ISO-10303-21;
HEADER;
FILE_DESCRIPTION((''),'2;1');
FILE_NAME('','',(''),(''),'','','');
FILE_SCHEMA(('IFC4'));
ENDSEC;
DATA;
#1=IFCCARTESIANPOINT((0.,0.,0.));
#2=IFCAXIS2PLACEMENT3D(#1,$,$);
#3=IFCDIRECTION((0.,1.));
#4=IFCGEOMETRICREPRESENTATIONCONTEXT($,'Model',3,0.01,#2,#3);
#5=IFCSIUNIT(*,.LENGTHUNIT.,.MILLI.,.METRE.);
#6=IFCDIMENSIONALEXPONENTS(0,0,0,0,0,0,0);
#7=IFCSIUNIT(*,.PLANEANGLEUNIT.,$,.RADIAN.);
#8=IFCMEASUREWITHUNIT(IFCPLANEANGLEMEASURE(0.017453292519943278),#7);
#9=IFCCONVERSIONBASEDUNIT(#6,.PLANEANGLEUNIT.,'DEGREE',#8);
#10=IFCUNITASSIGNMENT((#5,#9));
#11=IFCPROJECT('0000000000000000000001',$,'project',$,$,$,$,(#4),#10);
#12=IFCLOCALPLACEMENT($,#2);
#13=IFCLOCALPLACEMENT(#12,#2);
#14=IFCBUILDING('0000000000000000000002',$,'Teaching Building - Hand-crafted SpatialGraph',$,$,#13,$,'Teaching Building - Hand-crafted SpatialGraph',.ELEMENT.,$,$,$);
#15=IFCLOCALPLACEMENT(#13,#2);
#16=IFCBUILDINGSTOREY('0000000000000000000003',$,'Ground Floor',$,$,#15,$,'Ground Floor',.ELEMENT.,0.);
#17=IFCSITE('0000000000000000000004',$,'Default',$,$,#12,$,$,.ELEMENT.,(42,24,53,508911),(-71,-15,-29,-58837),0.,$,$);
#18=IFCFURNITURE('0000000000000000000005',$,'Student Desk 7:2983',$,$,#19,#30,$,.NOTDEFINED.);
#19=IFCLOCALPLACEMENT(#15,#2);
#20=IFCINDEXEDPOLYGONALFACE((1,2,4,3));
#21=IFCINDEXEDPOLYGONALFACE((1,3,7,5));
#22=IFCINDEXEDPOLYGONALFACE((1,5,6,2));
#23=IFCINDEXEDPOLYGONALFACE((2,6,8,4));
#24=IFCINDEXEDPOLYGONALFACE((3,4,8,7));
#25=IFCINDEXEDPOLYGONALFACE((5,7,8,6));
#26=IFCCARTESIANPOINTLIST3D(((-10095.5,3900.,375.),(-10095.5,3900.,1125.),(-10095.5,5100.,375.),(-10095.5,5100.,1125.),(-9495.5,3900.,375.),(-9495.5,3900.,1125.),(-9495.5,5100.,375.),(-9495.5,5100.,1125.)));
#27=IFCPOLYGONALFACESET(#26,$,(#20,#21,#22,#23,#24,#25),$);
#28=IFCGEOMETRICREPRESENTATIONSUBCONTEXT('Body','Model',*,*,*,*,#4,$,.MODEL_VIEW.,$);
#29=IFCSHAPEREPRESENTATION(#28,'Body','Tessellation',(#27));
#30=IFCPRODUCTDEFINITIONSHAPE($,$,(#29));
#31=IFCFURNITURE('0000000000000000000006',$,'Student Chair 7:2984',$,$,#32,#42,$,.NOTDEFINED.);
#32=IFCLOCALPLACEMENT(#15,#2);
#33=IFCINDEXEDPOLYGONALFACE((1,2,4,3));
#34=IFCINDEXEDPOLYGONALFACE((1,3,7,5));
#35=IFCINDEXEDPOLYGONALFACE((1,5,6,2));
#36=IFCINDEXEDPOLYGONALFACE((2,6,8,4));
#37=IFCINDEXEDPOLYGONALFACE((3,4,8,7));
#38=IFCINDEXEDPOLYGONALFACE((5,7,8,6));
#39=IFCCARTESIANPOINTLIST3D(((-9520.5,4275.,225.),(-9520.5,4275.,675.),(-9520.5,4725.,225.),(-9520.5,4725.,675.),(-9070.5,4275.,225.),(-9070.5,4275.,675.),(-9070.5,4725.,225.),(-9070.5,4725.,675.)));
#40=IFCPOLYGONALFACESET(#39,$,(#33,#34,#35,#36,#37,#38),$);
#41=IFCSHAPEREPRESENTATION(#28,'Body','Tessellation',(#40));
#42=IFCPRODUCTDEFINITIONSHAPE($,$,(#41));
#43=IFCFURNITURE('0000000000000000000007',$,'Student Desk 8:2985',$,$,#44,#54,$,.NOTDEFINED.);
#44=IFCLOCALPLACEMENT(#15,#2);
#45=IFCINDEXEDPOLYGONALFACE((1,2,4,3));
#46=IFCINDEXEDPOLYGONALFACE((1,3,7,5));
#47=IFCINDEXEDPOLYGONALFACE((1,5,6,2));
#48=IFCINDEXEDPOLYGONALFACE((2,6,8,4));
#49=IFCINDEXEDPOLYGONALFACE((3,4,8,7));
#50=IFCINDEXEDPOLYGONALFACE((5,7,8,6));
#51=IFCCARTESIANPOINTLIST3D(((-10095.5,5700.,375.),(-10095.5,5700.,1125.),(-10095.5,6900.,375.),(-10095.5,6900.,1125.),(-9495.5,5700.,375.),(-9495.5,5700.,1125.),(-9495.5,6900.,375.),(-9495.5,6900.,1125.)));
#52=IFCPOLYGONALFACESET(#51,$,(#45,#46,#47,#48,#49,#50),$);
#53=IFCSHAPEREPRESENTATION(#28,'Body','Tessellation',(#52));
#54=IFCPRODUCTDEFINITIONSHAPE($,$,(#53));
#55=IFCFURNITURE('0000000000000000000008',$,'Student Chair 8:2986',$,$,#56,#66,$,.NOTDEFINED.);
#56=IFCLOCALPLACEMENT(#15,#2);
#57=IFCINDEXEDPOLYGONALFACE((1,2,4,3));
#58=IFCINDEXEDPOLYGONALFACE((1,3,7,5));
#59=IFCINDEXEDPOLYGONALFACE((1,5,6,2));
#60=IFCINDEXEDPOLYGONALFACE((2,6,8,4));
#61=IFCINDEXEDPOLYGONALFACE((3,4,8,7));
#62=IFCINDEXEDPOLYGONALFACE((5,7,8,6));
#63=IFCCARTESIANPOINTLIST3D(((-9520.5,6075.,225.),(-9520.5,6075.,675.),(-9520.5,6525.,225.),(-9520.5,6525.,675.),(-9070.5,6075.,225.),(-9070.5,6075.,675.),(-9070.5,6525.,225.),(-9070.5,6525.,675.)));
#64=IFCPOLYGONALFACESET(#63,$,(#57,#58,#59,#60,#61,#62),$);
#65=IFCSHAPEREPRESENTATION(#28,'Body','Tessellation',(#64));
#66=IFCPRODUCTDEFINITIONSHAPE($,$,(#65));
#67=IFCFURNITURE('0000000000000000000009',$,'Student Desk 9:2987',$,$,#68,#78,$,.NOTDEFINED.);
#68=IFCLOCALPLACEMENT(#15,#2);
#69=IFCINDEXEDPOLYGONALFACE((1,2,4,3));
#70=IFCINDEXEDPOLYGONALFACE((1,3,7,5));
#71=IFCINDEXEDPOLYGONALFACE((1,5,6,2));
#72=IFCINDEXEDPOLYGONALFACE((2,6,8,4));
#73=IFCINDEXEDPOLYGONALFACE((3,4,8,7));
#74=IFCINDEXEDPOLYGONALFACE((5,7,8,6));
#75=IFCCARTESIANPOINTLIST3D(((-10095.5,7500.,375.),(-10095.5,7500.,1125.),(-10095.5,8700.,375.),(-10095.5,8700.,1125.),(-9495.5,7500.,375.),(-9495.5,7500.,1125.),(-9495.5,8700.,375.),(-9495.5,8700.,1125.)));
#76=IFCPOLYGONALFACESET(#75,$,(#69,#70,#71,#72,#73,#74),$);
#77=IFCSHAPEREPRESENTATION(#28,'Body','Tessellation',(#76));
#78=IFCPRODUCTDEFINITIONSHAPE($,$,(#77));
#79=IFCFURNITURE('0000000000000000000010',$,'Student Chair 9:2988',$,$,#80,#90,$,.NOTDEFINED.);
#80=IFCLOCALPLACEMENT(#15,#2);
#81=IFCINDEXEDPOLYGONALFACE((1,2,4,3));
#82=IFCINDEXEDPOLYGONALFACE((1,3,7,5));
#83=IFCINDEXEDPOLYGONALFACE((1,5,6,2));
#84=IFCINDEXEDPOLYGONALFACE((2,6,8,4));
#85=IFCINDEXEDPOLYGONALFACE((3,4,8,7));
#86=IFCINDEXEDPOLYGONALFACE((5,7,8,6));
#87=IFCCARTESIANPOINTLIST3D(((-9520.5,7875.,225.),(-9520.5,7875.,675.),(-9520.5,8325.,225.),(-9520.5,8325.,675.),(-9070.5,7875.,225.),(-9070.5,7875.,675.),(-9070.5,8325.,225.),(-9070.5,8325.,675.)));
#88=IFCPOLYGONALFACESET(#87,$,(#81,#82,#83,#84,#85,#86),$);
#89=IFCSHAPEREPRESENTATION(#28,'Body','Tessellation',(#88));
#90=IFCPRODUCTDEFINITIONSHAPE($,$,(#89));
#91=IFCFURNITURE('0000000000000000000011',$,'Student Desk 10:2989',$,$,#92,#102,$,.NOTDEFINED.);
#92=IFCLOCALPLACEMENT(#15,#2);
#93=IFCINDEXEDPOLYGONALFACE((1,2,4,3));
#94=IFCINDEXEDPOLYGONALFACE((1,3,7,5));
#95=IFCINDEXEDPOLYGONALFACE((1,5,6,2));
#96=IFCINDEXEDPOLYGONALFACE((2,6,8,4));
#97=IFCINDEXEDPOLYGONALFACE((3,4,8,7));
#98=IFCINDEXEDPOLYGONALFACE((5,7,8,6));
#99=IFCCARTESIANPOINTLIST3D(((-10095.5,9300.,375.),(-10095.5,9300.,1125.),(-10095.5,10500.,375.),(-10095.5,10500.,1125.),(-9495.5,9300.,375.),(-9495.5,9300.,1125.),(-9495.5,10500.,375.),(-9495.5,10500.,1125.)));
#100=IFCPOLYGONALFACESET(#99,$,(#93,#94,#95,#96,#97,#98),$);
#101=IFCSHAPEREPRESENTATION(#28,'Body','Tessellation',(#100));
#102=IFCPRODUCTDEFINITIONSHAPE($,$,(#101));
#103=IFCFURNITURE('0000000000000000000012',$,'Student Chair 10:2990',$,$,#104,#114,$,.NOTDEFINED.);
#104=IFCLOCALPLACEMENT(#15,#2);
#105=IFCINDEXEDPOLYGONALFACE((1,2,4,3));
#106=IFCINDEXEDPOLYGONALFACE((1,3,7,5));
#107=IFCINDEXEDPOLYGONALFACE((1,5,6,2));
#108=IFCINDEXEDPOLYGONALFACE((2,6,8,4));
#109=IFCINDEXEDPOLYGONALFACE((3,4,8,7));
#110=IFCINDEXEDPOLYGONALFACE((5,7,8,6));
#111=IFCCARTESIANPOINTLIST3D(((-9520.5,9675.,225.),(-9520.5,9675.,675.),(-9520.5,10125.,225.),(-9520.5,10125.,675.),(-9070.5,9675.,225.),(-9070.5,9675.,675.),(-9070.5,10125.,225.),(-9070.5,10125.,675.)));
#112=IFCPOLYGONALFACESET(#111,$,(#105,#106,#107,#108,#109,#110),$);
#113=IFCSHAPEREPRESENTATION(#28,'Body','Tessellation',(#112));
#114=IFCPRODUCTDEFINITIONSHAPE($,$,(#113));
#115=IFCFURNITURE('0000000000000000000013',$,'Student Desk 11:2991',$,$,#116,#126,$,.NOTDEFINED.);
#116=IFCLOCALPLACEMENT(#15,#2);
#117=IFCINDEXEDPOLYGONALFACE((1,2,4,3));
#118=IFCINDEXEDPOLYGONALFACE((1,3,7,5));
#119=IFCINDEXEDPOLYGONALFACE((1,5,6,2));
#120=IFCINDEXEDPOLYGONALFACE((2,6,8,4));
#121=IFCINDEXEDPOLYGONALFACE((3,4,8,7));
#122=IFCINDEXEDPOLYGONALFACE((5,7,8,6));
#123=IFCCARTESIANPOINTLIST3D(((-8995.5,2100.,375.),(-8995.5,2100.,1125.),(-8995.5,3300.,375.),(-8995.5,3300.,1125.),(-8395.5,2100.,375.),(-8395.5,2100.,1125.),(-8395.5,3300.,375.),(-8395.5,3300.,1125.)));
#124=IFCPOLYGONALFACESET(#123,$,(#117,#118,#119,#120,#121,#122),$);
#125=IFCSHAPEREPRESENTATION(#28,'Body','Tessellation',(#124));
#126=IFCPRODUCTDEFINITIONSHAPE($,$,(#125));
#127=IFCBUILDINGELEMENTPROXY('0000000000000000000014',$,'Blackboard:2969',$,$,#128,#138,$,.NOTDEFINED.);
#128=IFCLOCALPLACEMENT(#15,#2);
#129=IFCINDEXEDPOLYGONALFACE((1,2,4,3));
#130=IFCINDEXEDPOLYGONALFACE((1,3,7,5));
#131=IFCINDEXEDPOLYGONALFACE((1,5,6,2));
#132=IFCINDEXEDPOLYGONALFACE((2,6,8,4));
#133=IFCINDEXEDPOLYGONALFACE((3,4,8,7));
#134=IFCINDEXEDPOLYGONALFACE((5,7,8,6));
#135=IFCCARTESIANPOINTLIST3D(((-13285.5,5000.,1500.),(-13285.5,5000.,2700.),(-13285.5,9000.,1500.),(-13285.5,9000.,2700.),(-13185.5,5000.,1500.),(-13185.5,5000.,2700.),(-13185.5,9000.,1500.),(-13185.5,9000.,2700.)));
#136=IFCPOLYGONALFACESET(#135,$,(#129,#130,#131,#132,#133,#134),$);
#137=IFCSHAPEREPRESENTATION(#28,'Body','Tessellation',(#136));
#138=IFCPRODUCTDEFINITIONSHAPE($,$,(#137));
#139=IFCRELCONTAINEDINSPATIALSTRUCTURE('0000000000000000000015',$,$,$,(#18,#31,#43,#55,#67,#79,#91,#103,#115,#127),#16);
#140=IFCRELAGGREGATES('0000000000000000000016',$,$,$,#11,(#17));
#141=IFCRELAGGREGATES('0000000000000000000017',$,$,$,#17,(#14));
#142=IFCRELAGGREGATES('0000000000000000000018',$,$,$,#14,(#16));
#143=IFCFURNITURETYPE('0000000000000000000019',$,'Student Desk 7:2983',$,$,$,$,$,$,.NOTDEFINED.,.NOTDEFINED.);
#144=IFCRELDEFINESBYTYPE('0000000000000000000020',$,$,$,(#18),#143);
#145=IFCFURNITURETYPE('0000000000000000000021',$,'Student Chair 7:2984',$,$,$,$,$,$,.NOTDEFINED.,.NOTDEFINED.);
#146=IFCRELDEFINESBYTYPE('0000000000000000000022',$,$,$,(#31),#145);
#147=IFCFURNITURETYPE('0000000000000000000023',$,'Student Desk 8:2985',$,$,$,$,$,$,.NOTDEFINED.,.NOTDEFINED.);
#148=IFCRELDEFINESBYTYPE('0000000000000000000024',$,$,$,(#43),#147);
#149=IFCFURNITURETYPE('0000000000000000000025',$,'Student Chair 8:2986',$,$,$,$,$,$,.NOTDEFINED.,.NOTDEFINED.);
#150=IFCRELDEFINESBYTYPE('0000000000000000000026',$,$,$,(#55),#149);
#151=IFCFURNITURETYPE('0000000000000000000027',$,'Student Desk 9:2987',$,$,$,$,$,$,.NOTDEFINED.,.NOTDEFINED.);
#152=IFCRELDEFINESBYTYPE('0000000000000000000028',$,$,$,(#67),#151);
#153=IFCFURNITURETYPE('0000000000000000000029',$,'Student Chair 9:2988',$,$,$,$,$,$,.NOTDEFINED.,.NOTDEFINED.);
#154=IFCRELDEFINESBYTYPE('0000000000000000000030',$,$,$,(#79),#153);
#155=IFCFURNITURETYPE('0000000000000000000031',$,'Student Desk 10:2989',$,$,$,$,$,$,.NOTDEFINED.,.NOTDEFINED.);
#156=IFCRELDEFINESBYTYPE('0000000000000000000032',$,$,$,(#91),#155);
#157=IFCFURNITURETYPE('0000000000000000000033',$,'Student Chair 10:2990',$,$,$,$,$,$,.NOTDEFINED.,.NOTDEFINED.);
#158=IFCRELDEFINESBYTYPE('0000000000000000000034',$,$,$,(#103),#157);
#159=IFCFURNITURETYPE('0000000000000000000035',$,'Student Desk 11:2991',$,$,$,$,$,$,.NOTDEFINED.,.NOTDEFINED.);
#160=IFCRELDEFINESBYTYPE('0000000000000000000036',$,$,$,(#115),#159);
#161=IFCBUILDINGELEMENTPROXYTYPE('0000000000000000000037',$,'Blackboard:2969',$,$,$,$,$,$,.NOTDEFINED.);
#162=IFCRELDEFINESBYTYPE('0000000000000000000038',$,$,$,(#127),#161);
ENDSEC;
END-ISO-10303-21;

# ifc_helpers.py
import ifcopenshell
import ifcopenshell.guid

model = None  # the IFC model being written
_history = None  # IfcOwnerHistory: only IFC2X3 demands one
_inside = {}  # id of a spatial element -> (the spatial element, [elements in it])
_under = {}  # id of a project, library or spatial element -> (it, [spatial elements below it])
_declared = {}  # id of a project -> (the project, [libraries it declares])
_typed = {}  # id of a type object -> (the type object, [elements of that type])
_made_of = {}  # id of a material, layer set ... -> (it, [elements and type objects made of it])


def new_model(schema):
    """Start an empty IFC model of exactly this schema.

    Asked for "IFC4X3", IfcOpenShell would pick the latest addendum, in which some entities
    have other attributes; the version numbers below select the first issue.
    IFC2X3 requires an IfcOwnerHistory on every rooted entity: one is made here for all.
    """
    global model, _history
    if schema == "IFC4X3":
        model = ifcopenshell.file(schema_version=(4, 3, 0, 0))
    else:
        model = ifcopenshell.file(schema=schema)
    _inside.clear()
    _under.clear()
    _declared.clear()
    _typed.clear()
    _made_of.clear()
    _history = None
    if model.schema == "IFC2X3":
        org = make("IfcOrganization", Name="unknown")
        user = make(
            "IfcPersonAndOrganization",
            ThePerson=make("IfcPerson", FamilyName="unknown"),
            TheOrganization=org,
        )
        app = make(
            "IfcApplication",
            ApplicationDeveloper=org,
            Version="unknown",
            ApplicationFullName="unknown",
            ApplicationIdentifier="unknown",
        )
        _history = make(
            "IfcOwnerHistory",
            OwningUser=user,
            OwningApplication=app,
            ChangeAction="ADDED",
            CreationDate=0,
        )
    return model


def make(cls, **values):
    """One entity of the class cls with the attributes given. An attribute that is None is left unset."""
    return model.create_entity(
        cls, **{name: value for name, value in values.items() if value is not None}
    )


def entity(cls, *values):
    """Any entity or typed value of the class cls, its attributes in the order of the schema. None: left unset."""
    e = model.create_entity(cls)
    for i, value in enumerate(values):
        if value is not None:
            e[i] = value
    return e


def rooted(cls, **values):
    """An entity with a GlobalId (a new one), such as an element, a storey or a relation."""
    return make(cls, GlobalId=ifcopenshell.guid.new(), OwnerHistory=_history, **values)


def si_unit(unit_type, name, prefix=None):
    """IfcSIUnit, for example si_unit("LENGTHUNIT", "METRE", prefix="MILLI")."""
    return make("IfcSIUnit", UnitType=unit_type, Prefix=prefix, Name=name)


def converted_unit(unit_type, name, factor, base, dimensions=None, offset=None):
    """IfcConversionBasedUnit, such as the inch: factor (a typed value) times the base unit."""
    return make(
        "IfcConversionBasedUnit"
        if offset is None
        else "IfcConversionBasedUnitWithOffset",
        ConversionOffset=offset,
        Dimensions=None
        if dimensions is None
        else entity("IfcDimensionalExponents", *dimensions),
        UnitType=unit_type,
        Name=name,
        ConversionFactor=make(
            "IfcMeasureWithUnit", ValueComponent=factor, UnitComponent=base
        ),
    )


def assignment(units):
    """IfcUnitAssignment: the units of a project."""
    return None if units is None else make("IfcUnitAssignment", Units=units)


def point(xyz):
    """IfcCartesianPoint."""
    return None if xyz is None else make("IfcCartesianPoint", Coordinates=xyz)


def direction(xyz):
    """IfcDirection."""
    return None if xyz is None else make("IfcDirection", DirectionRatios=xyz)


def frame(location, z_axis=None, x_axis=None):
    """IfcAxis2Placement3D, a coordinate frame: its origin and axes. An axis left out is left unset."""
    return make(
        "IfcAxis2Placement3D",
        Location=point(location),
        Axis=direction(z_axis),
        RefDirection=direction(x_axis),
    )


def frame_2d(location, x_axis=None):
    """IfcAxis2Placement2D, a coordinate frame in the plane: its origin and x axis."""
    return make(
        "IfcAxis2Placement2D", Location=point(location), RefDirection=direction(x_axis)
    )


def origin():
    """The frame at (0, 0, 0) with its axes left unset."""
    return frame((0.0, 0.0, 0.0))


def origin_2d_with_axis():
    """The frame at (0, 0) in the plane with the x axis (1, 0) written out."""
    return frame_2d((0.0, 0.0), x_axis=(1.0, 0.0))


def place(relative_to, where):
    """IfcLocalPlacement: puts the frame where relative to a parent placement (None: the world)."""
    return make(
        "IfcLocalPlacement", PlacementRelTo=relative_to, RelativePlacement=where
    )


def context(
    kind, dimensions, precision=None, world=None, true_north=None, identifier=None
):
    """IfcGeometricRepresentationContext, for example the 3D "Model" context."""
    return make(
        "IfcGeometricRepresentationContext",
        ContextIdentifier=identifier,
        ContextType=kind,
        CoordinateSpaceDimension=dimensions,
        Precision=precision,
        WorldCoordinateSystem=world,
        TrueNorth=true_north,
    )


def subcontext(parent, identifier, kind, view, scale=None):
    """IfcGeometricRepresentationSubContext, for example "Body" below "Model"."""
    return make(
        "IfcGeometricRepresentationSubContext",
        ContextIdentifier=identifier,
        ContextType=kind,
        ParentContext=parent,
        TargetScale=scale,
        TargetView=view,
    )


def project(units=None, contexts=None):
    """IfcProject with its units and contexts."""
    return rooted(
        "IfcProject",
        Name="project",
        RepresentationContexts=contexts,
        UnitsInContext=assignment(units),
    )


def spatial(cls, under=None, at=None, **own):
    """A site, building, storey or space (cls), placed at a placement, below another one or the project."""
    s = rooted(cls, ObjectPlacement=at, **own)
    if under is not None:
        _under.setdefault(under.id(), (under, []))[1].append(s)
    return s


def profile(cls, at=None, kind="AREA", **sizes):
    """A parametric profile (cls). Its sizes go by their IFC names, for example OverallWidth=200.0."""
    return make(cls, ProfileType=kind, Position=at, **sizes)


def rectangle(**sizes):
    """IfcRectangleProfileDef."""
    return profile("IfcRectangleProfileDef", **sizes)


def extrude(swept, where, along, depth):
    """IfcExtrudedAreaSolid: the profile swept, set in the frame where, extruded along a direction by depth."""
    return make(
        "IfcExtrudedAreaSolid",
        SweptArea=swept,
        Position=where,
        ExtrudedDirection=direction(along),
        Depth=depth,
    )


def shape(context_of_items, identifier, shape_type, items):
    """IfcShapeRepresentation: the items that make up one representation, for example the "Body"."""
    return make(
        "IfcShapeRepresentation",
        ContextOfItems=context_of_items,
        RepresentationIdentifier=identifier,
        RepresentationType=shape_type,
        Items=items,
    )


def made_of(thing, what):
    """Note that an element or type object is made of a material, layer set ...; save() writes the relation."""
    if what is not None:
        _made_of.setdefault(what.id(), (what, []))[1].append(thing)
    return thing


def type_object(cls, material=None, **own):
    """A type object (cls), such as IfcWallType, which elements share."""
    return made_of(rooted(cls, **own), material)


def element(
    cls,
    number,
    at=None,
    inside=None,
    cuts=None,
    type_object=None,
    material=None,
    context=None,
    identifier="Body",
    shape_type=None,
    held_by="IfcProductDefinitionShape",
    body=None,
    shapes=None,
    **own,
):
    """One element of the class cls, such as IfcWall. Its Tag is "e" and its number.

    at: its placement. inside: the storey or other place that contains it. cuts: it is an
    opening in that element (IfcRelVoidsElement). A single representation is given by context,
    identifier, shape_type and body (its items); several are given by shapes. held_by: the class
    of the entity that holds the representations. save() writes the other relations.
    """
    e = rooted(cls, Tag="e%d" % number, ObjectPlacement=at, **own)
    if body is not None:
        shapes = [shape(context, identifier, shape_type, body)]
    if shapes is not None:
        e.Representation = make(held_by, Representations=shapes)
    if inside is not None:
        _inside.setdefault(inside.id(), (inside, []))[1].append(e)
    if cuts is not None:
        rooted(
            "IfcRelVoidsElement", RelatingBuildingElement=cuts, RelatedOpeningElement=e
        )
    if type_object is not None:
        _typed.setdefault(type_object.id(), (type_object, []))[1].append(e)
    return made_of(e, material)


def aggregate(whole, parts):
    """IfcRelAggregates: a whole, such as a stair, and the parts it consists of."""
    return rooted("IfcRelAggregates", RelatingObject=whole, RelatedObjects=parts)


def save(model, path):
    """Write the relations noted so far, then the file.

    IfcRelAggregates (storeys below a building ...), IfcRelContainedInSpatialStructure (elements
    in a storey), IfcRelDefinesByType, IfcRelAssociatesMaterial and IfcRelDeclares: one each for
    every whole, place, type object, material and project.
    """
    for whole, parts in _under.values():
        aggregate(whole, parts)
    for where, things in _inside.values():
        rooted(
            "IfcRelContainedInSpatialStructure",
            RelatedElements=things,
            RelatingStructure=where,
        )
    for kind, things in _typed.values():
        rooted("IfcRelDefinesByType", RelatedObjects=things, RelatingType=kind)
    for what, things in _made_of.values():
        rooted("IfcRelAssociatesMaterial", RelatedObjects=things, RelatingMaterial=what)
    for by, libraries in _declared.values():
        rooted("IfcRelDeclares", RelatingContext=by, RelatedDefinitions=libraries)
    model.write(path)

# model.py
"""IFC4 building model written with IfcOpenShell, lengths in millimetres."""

from ifc_helpers import new_model, entity, si_unit, converted_unit, direction, frame, frame_2d, origin, origin_2d_with_axis, place, context, subcontext, project, spatial, rectangle, extrude, type_object, element, save


model = new_model("IFC4")

# Units and contexts
model_context = context("Model", 3, precision=0.01, world=origin(), true_north=direction((0.0, 1.0)))
body_context = subcontext(model_context, "Body", "Model", "MODEL_VIEW")
ifc_project = project(units=[si_unit("LENGTHUNIT", "METRE", prefix="MILLI"), converted_unit("PLANEANGLEUNIT", "DEGREE", entity("IfcPlaneAngleMeasure", 0.017453292519943278), si_unit("PLANEANGLEUNIT", "RADIAN"), dimensions=[0, 0, 0, 0, 0, 0, 0])], contexts=[model_context])

# Site, building, storey
site_placement = place(None, origin())
site = spatial("IfcSite", under=ifc_project, at=site_placement, Name="Default", CompositionType="ELEMENT", RefLatitude=(42, 24, 53, 508911), RefLongitude=(-71, -15, -29, -58837), RefElevation=0.0)
building_placement = place(site_placement, origin())
building = spatial("IfcBuilding", under=site, at=building_placement, Name="Teaching Building - Hand-crafted SpatialGraph", LongName="Teaching Building - Hand-crafted SpatialGraph", CompositionType="ELEMENT")
storey_placement = place(building_placement, origin())
storey = spatial("IfcBuildingStorey", under=building, at=storey_placement, Name="Ground Floor", LongName="Ground Floor", CompositionType="ELEMENT", Elevation=0.0)

# Furniture
furniture_type_1 = type_object("IfcFurnitureType", Name="Student Desk 7:2983", PredefinedType="NOTDEFINED")
furniture_1_placement = place(storey_placement, origin())
element("IfcFurniture", 1, at=furniture_1_placement, inside=storey, type_object=furniture_type_1, Name="Student Desk 7:2983", PredefinedType="NOTDEFINED", context=body_context, shape_type="SweptSolid", body=[
    extrude(rectangle(XDim=1200.0, YDim=600.0, at=frame_2d((0.0, 0.0), x_axis=(1.0, 0.0))), frame((-9795.5, 4500.0, 375.0), z_axis=(0.0, 0.0, 1.0), x_axis=(0.0, 1.0, 0.0)), (0.0, 0.0, 1.0), 750.0),
])
furniture_type_2 = type_object("IfcFurnitureType", Name="Student Chair 7:2984", PredefinedType="NOTDEFINED")
furniture_2_placement = place(storey_placement, origin())
element("IfcFurniture", 2, at=furniture_2_placement, inside=storey, type_object=furniture_type_2, Name="Student Chair 7:2984", PredefinedType="NOTDEFINED", context=body_context, shape_type="SweptSolid", body=[
    extrude(rectangle(XDim=450.0, YDim=450.0, at=origin_2d_with_axis()), frame((-9295.5, 4500.0, 225.0)), (0.0, 0.0, 1.0), 450.0),
])
furniture_type_3 = type_object("IfcFurnitureType", Name="Student Desk 8:2985", PredefinedType="NOTDEFINED")
furniture_3_placement = place(storey_placement, origin())
element("IfcFurniture", 3, at=furniture_3_placement, inside=storey, type_object=furniture_type_3, Name="Student Desk 8:2985", PredefinedType="NOTDEFINED", context=body_context, shape_type="SweptSolid", body=[
    extrude(rectangle(XDim=1200.0, YDim=600.0, at=frame_2d((0.0, 0.0), x_axis=(1.0, 0.0))), frame((-9795.5, 6300.0, 375.0), z_axis=(0.0, 0.0, 1.0), x_axis=(0.0, 1.0, 0.0)), (0.0, 0.0, 1.0), 750.0),
])
furniture_type_4 = type_object("IfcFurnitureType", Name="Student Chair 8:2986", PredefinedType="NOTDEFINED")
furniture_4_placement = place(storey_placement, origin())
element("IfcFurniture", 4, at=furniture_4_placement, inside=storey, type_object=furniture_type_4, Name="Student Chair 8:2986", PredefinedType="NOTDEFINED", context=body_context, shape_type="SweptSolid", body=[
    extrude(rectangle(XDim=450.0, YDim=450.0, at=origin_2d_with_axis()), frame((-9295.5, 6300.0, 225.0)), (0.0, 0.0, 1.0), 450.0),
])
furniture_type_5 = type_object("IfcFurnitureType", Name="Student Desk 9:2987", PredefinedType="NOTDEFINED")
furniture_5_placement = place(storey_placement, origin())
element("IfcFurniture", 5, at=furniture_5_placement, inside=storey, type_object=furniture_type_5, Name="Student Desk 9:2987", PredefinedType="NOTDEFINED", context=body_context, shape_type="SweptSolid", body=[
    extrude(rectangle(XDim=1200.0, YDim=600.0, at=frame_2d((0.0, 0.0), x_axis=(1.0, 0.0))), frame((-9795.5, 8100.0, 375.0), z_axis=(0.0, 0.0, 1.0), x_axis=(0.0, 1.0, 0.0)), (0.0, 0.0, 1.0), 750.0),
])
furniture_type_6 = type_object("IfcFurnitureType", Name="Student Chair 9:2988", PredefinedType="NOTDEFINED")
furniture_6_placement = place(storey_placement, origin())
element("IfcFurniture", 6, at=furniture_6_placement, inside=storey, type_object=furniture_type_6, Name="Student Chair 9:2988", PredefinedType="NOTDEFINED", context=body_context, shape_type="SweptSolid", body=[
    extrude(rectangle(XDim=450.0, YDim=450.0, at=origin_2d_with_axis()), frame((-9295.5, 8100.0, 225.0)), (0.0, 0.0, 1.0), 450.0),
])
furniture_type_7 = type_object("IfcFurnitureType", Name="Student Desk 10:2989", PredefinedType="NOTDEFINED")
furniture_7_placement = place(storey_placement, origin())
element("IfcFurniture", 7, at=furniture_7_placement, inside=storey, type_object=furniture_type_7, Name="Student Desk 10:2989", PredefinedType="NOTDEFINED", context=body_context, shape_type="SweptSolid", body=[
    extrude(rectangle(XDim=1200.0, YDim=600.0, at=frame_2d((0.0, 0.0), x_axis=(1.0, 0.0))), frame((-9795.5, 9900.0, 375.0), z_axis=(0.0, 0.0, 1.0), x_axis=(0.0, 1.0, 0.0)), (0.0, 0.0, 1.0), 750.0),
])
furniture_type_8 = type_object("IfcFurnitureType", Name="Student Chair 10:2990", PredefinedType="NOTDEFINED")
furniture_8_placement = place(storey_placement, origin())
element("IfcFurniture", 8, at=furniture_8_placement, inside=storey, type_object=furniture_type_8, Name="Student Chair 10:2990", PredefinedType="NOTDEFINED", context=body_context, shape_type="SweptSolid", body=[
    extrude(rectangle(XDim=450.0, YDim=450.0, at=frame_2d((0.0, 0.0), x_axis=(1.0, 0.0))), frame((-9295.5, 9900.0, 225.0)), (0.0, 0.0, 1.0), 450.0),
])
furniture_type_9 = type_object("IfcFurnitureType", Name="Student Desk 11:2991", PredefinedType="NOTDEFINED")
furniture_9_placement = place(storey_placement, origin())
element("IfcFurniture", 9, at=furniture_9_placement, inside=storey, type_object=furniture_type_9, Name="Student Desk 11:2991", PredefinedType="NOTDEFINED", context=body_context, shape_type="SweptSolid", body=[
    extrude(rectangle(XDim=1200.0, YDim=600.0, at=frame_2d((0.0, 0.0), x_axis=(1.0, 0.0))), frame((-8695.5, 2700.0, 375.0), z_axis=(0.0, 0.0, 1.0), x_axis=(0.0, 1.0, 0.0)), (0.0, 0.0, 1.0), 750.0),
])

# Building element proxy
building_element_proxy_type = type_object("IfcBuildingElementProxyType", Name="Blackboard:2969", PredefinedType="NOTDEFINED")
proxy_placement = place(storey_placement, origin())
element("IfcBuildingElementProxy", 10, at=proxy_placement, inside=storey, type_object=building_element_proxy_type, Name="Blackboard:2969", PredefinedType="NOTDEFINED", context=body_context, shape_type="SweptSolid", body=[
    extrude(rectangle(XDim=100.0, YDim=4000.0, at=origin_2d_with_axis()), frame((-13235.5, 7000.0, 1500.0)), (0.0, 0.0, 1.0), 1200.0),
])

save(model, "model.ifc")
